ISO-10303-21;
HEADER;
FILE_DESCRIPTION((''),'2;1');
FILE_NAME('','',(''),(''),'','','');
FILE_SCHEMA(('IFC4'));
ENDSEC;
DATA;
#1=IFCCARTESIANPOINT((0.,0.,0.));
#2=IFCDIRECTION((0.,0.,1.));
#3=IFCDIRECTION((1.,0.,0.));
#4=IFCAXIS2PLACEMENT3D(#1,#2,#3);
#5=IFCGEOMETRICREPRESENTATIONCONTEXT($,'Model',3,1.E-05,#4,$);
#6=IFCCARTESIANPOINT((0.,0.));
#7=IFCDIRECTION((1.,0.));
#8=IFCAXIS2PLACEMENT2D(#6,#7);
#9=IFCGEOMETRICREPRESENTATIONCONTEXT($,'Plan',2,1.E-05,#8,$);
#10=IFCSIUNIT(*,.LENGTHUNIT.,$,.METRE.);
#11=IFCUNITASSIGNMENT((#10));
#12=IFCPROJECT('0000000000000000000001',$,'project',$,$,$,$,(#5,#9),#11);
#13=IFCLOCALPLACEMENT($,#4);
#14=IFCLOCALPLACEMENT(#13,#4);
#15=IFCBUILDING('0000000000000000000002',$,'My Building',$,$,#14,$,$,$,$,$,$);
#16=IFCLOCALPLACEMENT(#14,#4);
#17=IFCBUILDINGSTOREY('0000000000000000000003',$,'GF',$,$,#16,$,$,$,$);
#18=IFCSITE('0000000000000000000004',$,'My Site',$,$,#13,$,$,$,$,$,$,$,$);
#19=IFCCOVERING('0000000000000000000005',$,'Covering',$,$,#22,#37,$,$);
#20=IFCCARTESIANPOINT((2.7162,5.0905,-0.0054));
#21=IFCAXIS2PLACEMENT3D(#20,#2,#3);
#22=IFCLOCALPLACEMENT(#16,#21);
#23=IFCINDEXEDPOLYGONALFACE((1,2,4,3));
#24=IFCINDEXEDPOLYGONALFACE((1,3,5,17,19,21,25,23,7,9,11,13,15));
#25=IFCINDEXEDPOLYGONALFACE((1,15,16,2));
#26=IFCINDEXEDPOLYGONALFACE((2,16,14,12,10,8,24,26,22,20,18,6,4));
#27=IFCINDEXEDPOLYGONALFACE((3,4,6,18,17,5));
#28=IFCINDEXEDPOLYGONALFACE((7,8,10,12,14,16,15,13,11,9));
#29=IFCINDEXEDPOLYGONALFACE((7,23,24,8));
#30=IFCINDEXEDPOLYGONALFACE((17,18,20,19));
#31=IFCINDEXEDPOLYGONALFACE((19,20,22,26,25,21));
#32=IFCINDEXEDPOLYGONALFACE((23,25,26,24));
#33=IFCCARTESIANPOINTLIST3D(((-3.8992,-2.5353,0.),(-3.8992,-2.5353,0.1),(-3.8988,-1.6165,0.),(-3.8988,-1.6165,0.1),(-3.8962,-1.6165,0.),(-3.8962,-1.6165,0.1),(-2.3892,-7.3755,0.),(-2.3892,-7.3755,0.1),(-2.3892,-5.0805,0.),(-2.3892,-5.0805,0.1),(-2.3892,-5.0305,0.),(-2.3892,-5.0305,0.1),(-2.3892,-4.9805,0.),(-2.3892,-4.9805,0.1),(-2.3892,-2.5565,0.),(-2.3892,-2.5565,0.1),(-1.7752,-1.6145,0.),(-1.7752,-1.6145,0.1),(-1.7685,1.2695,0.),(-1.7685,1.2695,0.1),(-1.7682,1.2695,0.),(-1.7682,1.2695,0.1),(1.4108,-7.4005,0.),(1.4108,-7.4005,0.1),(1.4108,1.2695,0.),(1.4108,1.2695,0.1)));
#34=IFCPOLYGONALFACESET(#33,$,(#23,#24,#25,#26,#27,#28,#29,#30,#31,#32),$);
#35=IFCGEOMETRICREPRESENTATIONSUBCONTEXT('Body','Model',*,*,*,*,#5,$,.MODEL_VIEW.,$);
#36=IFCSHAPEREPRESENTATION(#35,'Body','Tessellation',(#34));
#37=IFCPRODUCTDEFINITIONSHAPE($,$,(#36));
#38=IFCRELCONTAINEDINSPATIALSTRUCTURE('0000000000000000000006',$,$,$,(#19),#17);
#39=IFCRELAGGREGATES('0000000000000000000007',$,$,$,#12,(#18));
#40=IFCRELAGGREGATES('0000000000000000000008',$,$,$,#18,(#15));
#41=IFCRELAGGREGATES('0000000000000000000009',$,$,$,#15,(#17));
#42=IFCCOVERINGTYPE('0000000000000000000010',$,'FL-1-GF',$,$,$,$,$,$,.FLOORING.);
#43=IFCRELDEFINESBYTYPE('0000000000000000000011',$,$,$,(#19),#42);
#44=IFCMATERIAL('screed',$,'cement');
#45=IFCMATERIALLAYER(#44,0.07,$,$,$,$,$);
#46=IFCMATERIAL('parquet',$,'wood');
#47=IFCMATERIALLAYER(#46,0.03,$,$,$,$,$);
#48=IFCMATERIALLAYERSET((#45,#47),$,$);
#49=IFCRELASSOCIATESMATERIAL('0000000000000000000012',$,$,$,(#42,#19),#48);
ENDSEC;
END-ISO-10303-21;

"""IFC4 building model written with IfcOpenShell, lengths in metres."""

from ifc_helpers import new_model, si_unit, frame, origin_with_axes, origin_2d_with_axis, place, context, subcontext, project, spatial, line, indexed_curve, outline, extrude, material, layer, layer_set, layer_usage, type_object, element, save


model = new_model("IFC4")

# Units and contexts
model_context = context("Model", 3, precision=1e-05, world=origin_with_axes())
plan_context = context("Plan", 2, precision=1e-05, world=origin_2d_with_axis())
body_context_1 = subcontext(model_context, "Body", "Model", "MODEL_VIEW")
ifc_project = project(units=[si_unit("LENGTHUNIT", "METRE")], contexts=[model_context, plan_context])

# Site, building, storey
site_placement = place(None, origin_with_axes())
site = spatial("IfcSite", under=ifc_project, at=site_placement, Name="My Site")
building_placement = place(site_placement, origin_with_axes())
building = spatial("IfcBuilding", under=site, at=building_placement, Name="My Building")
storey_placement = place(building_placement, origin_with_axes())
storey = spatial("IfcBuildingStorey", under=building, at=storey_placement, Name="GF")

# Covering
ifc_material_1 = material(Name="screed", Category="cement")
ifc_layer_1 = layer(ifc_material_1, 0.07)
ifc_material_2 = material(Name="parquet", Category="wood")
ifc_layer_2 = layer(ifc_material_2, 0.03)
ifc_layer_set_1 = layer_set([ifc_layer_1, ifc_layer_2])
ifc_layer_usage_1 = layer_usage(ifc_layer_set_1, "AXIS3", "POSITIVE", 0.0)
covering_type = type_object("IfcCoveringType", Name="FL-1-GF", PredefinedType="FLOORING", material=ifc_layer_set_1)
covering_placement = place(storey_placement, frame((2.7162, 5.0905, -0.0054), z_axis=(0.0, 0.0, 1.0), x_axis=(1.0, 0.0, 0.0)))
element("IfcCovering", 1, at=covering_placement, inside=storey, type_object=covering_type, material=ifc_layer_usage_1, Name="Covering", context=body_context_1, shape_type="SweptSolid", body=[
    extrude(outline(indexed_curve([(-2.3892, -7.3755), (-2.3892, -5.0805), (-2.3892, -5.0305), (-2.3892, -5.0305), (-2.3892, -4.9805), (-2.3892, -2.5565), (-2.3892, -2.5565), (-3.8992, -2.5353), (-3.8988, -1.6165), (-3.8962, -1.6165), (-1.7752, -1.6145), (-1.7752, -1.6145), (-1.7685, 1.2695), (-1.7682, 1.2695), (1.4108, 1.2695), (1.4108, -7.4005)], segments=[line(1, 2, 3, 4, 5, 6, 7, 8, 9, 10, 11, 12, 13, 14, 15, 16, 1)])), origin_with_axes(), (0.0, 0.0, 1.0), 0.1),
])

save(model, "model.ifc")
